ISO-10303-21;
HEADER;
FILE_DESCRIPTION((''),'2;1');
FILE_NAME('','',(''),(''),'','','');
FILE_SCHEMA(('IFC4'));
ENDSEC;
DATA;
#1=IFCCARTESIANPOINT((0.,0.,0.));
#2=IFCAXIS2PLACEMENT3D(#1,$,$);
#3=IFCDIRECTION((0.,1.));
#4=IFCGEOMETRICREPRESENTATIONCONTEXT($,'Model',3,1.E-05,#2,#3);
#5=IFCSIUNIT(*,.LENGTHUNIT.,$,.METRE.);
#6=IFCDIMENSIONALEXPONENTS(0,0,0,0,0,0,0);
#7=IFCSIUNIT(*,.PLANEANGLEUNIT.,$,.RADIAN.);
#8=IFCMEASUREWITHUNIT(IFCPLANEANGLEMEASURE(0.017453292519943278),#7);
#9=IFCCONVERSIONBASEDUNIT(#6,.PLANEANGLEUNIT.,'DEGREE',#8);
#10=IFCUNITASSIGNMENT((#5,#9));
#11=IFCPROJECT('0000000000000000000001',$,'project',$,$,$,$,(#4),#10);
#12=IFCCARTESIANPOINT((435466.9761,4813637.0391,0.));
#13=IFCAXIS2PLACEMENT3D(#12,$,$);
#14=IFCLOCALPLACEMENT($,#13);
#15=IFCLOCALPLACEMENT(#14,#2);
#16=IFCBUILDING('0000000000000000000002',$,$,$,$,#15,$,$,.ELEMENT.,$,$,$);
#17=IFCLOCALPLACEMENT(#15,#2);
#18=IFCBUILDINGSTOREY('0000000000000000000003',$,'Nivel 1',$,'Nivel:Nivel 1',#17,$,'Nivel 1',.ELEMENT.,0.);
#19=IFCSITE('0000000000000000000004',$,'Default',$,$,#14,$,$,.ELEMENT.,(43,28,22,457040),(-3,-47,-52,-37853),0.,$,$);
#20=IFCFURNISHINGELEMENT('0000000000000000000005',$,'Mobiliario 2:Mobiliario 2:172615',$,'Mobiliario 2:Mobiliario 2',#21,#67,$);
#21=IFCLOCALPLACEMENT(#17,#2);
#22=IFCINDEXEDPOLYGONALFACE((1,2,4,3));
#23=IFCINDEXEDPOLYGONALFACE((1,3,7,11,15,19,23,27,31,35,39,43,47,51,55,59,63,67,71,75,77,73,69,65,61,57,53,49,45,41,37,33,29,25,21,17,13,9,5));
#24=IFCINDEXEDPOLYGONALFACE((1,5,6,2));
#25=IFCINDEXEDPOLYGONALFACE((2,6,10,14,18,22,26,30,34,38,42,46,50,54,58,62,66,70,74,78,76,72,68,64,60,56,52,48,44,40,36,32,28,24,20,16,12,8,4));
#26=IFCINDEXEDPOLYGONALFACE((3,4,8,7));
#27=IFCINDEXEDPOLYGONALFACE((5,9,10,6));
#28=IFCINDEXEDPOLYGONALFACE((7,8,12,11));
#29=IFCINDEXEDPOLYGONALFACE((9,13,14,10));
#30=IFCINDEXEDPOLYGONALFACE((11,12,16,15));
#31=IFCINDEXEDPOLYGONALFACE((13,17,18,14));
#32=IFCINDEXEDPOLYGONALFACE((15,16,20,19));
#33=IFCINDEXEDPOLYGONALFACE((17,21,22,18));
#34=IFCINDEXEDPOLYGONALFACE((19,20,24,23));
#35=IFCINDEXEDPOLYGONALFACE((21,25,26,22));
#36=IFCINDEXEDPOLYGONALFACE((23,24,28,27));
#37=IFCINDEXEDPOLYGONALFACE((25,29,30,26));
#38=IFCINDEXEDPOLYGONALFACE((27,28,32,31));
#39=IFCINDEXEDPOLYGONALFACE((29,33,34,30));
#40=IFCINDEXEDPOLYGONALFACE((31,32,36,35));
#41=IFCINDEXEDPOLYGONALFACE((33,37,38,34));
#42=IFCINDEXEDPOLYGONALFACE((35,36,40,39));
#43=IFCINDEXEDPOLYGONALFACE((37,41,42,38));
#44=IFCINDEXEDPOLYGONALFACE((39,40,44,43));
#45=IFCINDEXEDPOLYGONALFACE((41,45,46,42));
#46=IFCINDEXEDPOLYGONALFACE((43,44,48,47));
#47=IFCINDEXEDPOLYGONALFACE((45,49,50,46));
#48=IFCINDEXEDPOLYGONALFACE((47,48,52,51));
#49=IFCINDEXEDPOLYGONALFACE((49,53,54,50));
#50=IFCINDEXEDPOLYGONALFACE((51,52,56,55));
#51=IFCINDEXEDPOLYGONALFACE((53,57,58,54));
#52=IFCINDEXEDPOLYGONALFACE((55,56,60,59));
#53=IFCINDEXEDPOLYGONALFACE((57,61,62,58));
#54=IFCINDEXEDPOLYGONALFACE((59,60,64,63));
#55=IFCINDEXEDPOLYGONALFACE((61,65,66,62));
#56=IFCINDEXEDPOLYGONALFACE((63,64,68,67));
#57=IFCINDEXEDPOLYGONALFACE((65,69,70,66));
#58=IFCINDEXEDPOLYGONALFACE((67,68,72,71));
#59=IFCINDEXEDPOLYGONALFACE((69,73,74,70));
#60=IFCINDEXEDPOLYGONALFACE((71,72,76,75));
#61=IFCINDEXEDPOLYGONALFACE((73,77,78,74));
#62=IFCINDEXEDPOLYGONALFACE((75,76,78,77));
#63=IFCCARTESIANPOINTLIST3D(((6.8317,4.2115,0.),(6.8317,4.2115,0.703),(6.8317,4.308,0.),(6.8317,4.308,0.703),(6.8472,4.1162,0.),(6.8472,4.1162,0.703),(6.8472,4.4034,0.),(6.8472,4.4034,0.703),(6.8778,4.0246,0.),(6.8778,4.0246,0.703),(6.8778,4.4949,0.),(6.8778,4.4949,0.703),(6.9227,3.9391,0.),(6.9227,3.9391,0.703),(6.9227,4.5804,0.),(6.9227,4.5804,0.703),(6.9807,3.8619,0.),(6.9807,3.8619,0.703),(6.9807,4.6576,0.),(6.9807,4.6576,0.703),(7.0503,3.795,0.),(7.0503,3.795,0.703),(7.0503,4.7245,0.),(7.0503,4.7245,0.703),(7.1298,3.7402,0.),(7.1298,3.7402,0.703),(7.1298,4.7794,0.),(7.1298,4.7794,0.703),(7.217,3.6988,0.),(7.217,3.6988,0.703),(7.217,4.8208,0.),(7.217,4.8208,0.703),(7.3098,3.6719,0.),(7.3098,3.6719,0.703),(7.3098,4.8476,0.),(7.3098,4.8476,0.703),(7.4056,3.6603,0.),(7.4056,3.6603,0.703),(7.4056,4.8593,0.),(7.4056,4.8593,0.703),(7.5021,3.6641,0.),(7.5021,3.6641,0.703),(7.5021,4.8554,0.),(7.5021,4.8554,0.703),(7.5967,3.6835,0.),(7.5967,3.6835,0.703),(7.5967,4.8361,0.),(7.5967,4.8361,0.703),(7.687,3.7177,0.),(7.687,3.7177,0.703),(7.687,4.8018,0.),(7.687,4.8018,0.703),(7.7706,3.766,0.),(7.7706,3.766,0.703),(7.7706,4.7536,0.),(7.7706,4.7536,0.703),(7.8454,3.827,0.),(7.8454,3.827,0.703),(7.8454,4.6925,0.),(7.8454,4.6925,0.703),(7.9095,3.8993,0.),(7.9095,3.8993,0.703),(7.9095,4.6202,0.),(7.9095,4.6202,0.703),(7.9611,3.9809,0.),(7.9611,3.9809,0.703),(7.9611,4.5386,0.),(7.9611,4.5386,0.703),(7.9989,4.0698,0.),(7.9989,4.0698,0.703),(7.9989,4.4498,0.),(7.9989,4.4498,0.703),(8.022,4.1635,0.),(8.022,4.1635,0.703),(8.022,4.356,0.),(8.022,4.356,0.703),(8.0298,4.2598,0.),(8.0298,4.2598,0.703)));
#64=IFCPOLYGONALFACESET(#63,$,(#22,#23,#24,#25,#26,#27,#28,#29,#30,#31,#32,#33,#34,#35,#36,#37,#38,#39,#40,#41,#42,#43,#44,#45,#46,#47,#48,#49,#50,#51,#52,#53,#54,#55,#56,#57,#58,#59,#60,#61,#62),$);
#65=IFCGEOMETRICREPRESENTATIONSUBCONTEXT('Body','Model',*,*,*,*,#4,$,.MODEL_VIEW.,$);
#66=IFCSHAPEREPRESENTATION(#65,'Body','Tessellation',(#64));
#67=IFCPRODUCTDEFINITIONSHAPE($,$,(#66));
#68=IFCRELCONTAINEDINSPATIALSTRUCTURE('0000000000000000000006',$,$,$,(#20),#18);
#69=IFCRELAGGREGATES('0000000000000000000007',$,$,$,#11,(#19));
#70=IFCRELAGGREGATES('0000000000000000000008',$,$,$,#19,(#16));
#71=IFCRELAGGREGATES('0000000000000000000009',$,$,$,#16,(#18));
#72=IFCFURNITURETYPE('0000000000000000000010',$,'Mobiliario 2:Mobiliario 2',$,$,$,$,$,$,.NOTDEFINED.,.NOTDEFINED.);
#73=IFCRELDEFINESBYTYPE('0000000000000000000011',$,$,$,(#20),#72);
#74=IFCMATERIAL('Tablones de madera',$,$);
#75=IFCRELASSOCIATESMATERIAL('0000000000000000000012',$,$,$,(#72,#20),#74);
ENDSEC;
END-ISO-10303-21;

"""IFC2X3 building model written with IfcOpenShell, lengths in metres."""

from ifc_helpers import new_model, entity, si_unit, converted_unit, direction, frame, frame_2d, origin, place, context, subcontext, project, spatial, circle, extrude, source, transform, mapped, material, type_object, type_shapes, element, save


model = new_model("IFC2X3")

# Units and contexts
model_context = context("Model", 3, precision=1e-05, world=origin(), true_north=direction((0.0, 1.0)))
body_context = subcontext(model_context, "Body", "Model", "MODEL_VIEW")
ifc_project = project(units=[si_unit("LENGTHUNIT", "METRE"), converted_unit("PLANEANGLEUNIT", "DEGREE", entity("IfcPlaneAngleMeasure", 0.017453292519943278), si_unit("PLANEANGLEUNIT", "RADIAN"), dimensions=[0, 0, 0, 0, 0, 0, 0])], contexts=[model_context])

# Site, building, storey
site_placement = place(None, frame((435466.9761, 4813637.0391, 0.0)))
site = spatial("IfcSite", under=ifc_project, at=site_placement, Name="Default", CompositionType="ELEMENT", RefLatitude=(43, 28, 22, 457040), RefLongitude=(-3, -47, -52, -37853), RefElevation=0.0)
building_placement = place(site_placement, origin())
building = spatial("IfcBuilding", under=site, at=building_placement, CompositionType="ELEMENT")
storey_placement = place(building_placement, origin())
storey = spatial("IfcBuildingStorey", under=building, at=storey_placement, Name="Nivel 1", ObjectType="Nivel:Nivel 1", LongName="Nivel 1", CompositionType="ELEMENT", Elevation=0.0)

# Furnishing element
ifc_material_1 = material(Name="Tablones de madera")
furniture_type_1 = type_object("IfcFurnitureType", Name="Mobiliario 2:Mobiliario 2", AssemblyPlace="NOTDEFINED", material=ifc_material_1)
shared_shape_1 = source(origin(), body_context, "Body", "SweptSolid", [
    extrude(circle(Radius=0.6, at=frame_2d((0.0, 0.0), x_axis=(1.0, 0.0))), frame((7.4298, 4.2598, 0.0)), (0.0, 0.0, 1.0), 0.703),
])
type_shapes(furniture_type_1, [shared_shape_1])
furnishing_1_placement = place(storey_placement, origin())
element("IfcFurnishingElement", 1, at=furnishing_1_placement, inside=storey, type_object=furniture_type_1, material=ifc_material_1, Name="Mobiliario 2:Mobiliario 2:172615", ObjectType="Mobiliario 2:Mobiliario 2", context=body_context, shape_type="MappedRepresentation", body=[
    mapped(shared_shape_1, transform((0.0, 0.0, 0.0), scale=1.0)),
])

save(model, "model.ifc")
